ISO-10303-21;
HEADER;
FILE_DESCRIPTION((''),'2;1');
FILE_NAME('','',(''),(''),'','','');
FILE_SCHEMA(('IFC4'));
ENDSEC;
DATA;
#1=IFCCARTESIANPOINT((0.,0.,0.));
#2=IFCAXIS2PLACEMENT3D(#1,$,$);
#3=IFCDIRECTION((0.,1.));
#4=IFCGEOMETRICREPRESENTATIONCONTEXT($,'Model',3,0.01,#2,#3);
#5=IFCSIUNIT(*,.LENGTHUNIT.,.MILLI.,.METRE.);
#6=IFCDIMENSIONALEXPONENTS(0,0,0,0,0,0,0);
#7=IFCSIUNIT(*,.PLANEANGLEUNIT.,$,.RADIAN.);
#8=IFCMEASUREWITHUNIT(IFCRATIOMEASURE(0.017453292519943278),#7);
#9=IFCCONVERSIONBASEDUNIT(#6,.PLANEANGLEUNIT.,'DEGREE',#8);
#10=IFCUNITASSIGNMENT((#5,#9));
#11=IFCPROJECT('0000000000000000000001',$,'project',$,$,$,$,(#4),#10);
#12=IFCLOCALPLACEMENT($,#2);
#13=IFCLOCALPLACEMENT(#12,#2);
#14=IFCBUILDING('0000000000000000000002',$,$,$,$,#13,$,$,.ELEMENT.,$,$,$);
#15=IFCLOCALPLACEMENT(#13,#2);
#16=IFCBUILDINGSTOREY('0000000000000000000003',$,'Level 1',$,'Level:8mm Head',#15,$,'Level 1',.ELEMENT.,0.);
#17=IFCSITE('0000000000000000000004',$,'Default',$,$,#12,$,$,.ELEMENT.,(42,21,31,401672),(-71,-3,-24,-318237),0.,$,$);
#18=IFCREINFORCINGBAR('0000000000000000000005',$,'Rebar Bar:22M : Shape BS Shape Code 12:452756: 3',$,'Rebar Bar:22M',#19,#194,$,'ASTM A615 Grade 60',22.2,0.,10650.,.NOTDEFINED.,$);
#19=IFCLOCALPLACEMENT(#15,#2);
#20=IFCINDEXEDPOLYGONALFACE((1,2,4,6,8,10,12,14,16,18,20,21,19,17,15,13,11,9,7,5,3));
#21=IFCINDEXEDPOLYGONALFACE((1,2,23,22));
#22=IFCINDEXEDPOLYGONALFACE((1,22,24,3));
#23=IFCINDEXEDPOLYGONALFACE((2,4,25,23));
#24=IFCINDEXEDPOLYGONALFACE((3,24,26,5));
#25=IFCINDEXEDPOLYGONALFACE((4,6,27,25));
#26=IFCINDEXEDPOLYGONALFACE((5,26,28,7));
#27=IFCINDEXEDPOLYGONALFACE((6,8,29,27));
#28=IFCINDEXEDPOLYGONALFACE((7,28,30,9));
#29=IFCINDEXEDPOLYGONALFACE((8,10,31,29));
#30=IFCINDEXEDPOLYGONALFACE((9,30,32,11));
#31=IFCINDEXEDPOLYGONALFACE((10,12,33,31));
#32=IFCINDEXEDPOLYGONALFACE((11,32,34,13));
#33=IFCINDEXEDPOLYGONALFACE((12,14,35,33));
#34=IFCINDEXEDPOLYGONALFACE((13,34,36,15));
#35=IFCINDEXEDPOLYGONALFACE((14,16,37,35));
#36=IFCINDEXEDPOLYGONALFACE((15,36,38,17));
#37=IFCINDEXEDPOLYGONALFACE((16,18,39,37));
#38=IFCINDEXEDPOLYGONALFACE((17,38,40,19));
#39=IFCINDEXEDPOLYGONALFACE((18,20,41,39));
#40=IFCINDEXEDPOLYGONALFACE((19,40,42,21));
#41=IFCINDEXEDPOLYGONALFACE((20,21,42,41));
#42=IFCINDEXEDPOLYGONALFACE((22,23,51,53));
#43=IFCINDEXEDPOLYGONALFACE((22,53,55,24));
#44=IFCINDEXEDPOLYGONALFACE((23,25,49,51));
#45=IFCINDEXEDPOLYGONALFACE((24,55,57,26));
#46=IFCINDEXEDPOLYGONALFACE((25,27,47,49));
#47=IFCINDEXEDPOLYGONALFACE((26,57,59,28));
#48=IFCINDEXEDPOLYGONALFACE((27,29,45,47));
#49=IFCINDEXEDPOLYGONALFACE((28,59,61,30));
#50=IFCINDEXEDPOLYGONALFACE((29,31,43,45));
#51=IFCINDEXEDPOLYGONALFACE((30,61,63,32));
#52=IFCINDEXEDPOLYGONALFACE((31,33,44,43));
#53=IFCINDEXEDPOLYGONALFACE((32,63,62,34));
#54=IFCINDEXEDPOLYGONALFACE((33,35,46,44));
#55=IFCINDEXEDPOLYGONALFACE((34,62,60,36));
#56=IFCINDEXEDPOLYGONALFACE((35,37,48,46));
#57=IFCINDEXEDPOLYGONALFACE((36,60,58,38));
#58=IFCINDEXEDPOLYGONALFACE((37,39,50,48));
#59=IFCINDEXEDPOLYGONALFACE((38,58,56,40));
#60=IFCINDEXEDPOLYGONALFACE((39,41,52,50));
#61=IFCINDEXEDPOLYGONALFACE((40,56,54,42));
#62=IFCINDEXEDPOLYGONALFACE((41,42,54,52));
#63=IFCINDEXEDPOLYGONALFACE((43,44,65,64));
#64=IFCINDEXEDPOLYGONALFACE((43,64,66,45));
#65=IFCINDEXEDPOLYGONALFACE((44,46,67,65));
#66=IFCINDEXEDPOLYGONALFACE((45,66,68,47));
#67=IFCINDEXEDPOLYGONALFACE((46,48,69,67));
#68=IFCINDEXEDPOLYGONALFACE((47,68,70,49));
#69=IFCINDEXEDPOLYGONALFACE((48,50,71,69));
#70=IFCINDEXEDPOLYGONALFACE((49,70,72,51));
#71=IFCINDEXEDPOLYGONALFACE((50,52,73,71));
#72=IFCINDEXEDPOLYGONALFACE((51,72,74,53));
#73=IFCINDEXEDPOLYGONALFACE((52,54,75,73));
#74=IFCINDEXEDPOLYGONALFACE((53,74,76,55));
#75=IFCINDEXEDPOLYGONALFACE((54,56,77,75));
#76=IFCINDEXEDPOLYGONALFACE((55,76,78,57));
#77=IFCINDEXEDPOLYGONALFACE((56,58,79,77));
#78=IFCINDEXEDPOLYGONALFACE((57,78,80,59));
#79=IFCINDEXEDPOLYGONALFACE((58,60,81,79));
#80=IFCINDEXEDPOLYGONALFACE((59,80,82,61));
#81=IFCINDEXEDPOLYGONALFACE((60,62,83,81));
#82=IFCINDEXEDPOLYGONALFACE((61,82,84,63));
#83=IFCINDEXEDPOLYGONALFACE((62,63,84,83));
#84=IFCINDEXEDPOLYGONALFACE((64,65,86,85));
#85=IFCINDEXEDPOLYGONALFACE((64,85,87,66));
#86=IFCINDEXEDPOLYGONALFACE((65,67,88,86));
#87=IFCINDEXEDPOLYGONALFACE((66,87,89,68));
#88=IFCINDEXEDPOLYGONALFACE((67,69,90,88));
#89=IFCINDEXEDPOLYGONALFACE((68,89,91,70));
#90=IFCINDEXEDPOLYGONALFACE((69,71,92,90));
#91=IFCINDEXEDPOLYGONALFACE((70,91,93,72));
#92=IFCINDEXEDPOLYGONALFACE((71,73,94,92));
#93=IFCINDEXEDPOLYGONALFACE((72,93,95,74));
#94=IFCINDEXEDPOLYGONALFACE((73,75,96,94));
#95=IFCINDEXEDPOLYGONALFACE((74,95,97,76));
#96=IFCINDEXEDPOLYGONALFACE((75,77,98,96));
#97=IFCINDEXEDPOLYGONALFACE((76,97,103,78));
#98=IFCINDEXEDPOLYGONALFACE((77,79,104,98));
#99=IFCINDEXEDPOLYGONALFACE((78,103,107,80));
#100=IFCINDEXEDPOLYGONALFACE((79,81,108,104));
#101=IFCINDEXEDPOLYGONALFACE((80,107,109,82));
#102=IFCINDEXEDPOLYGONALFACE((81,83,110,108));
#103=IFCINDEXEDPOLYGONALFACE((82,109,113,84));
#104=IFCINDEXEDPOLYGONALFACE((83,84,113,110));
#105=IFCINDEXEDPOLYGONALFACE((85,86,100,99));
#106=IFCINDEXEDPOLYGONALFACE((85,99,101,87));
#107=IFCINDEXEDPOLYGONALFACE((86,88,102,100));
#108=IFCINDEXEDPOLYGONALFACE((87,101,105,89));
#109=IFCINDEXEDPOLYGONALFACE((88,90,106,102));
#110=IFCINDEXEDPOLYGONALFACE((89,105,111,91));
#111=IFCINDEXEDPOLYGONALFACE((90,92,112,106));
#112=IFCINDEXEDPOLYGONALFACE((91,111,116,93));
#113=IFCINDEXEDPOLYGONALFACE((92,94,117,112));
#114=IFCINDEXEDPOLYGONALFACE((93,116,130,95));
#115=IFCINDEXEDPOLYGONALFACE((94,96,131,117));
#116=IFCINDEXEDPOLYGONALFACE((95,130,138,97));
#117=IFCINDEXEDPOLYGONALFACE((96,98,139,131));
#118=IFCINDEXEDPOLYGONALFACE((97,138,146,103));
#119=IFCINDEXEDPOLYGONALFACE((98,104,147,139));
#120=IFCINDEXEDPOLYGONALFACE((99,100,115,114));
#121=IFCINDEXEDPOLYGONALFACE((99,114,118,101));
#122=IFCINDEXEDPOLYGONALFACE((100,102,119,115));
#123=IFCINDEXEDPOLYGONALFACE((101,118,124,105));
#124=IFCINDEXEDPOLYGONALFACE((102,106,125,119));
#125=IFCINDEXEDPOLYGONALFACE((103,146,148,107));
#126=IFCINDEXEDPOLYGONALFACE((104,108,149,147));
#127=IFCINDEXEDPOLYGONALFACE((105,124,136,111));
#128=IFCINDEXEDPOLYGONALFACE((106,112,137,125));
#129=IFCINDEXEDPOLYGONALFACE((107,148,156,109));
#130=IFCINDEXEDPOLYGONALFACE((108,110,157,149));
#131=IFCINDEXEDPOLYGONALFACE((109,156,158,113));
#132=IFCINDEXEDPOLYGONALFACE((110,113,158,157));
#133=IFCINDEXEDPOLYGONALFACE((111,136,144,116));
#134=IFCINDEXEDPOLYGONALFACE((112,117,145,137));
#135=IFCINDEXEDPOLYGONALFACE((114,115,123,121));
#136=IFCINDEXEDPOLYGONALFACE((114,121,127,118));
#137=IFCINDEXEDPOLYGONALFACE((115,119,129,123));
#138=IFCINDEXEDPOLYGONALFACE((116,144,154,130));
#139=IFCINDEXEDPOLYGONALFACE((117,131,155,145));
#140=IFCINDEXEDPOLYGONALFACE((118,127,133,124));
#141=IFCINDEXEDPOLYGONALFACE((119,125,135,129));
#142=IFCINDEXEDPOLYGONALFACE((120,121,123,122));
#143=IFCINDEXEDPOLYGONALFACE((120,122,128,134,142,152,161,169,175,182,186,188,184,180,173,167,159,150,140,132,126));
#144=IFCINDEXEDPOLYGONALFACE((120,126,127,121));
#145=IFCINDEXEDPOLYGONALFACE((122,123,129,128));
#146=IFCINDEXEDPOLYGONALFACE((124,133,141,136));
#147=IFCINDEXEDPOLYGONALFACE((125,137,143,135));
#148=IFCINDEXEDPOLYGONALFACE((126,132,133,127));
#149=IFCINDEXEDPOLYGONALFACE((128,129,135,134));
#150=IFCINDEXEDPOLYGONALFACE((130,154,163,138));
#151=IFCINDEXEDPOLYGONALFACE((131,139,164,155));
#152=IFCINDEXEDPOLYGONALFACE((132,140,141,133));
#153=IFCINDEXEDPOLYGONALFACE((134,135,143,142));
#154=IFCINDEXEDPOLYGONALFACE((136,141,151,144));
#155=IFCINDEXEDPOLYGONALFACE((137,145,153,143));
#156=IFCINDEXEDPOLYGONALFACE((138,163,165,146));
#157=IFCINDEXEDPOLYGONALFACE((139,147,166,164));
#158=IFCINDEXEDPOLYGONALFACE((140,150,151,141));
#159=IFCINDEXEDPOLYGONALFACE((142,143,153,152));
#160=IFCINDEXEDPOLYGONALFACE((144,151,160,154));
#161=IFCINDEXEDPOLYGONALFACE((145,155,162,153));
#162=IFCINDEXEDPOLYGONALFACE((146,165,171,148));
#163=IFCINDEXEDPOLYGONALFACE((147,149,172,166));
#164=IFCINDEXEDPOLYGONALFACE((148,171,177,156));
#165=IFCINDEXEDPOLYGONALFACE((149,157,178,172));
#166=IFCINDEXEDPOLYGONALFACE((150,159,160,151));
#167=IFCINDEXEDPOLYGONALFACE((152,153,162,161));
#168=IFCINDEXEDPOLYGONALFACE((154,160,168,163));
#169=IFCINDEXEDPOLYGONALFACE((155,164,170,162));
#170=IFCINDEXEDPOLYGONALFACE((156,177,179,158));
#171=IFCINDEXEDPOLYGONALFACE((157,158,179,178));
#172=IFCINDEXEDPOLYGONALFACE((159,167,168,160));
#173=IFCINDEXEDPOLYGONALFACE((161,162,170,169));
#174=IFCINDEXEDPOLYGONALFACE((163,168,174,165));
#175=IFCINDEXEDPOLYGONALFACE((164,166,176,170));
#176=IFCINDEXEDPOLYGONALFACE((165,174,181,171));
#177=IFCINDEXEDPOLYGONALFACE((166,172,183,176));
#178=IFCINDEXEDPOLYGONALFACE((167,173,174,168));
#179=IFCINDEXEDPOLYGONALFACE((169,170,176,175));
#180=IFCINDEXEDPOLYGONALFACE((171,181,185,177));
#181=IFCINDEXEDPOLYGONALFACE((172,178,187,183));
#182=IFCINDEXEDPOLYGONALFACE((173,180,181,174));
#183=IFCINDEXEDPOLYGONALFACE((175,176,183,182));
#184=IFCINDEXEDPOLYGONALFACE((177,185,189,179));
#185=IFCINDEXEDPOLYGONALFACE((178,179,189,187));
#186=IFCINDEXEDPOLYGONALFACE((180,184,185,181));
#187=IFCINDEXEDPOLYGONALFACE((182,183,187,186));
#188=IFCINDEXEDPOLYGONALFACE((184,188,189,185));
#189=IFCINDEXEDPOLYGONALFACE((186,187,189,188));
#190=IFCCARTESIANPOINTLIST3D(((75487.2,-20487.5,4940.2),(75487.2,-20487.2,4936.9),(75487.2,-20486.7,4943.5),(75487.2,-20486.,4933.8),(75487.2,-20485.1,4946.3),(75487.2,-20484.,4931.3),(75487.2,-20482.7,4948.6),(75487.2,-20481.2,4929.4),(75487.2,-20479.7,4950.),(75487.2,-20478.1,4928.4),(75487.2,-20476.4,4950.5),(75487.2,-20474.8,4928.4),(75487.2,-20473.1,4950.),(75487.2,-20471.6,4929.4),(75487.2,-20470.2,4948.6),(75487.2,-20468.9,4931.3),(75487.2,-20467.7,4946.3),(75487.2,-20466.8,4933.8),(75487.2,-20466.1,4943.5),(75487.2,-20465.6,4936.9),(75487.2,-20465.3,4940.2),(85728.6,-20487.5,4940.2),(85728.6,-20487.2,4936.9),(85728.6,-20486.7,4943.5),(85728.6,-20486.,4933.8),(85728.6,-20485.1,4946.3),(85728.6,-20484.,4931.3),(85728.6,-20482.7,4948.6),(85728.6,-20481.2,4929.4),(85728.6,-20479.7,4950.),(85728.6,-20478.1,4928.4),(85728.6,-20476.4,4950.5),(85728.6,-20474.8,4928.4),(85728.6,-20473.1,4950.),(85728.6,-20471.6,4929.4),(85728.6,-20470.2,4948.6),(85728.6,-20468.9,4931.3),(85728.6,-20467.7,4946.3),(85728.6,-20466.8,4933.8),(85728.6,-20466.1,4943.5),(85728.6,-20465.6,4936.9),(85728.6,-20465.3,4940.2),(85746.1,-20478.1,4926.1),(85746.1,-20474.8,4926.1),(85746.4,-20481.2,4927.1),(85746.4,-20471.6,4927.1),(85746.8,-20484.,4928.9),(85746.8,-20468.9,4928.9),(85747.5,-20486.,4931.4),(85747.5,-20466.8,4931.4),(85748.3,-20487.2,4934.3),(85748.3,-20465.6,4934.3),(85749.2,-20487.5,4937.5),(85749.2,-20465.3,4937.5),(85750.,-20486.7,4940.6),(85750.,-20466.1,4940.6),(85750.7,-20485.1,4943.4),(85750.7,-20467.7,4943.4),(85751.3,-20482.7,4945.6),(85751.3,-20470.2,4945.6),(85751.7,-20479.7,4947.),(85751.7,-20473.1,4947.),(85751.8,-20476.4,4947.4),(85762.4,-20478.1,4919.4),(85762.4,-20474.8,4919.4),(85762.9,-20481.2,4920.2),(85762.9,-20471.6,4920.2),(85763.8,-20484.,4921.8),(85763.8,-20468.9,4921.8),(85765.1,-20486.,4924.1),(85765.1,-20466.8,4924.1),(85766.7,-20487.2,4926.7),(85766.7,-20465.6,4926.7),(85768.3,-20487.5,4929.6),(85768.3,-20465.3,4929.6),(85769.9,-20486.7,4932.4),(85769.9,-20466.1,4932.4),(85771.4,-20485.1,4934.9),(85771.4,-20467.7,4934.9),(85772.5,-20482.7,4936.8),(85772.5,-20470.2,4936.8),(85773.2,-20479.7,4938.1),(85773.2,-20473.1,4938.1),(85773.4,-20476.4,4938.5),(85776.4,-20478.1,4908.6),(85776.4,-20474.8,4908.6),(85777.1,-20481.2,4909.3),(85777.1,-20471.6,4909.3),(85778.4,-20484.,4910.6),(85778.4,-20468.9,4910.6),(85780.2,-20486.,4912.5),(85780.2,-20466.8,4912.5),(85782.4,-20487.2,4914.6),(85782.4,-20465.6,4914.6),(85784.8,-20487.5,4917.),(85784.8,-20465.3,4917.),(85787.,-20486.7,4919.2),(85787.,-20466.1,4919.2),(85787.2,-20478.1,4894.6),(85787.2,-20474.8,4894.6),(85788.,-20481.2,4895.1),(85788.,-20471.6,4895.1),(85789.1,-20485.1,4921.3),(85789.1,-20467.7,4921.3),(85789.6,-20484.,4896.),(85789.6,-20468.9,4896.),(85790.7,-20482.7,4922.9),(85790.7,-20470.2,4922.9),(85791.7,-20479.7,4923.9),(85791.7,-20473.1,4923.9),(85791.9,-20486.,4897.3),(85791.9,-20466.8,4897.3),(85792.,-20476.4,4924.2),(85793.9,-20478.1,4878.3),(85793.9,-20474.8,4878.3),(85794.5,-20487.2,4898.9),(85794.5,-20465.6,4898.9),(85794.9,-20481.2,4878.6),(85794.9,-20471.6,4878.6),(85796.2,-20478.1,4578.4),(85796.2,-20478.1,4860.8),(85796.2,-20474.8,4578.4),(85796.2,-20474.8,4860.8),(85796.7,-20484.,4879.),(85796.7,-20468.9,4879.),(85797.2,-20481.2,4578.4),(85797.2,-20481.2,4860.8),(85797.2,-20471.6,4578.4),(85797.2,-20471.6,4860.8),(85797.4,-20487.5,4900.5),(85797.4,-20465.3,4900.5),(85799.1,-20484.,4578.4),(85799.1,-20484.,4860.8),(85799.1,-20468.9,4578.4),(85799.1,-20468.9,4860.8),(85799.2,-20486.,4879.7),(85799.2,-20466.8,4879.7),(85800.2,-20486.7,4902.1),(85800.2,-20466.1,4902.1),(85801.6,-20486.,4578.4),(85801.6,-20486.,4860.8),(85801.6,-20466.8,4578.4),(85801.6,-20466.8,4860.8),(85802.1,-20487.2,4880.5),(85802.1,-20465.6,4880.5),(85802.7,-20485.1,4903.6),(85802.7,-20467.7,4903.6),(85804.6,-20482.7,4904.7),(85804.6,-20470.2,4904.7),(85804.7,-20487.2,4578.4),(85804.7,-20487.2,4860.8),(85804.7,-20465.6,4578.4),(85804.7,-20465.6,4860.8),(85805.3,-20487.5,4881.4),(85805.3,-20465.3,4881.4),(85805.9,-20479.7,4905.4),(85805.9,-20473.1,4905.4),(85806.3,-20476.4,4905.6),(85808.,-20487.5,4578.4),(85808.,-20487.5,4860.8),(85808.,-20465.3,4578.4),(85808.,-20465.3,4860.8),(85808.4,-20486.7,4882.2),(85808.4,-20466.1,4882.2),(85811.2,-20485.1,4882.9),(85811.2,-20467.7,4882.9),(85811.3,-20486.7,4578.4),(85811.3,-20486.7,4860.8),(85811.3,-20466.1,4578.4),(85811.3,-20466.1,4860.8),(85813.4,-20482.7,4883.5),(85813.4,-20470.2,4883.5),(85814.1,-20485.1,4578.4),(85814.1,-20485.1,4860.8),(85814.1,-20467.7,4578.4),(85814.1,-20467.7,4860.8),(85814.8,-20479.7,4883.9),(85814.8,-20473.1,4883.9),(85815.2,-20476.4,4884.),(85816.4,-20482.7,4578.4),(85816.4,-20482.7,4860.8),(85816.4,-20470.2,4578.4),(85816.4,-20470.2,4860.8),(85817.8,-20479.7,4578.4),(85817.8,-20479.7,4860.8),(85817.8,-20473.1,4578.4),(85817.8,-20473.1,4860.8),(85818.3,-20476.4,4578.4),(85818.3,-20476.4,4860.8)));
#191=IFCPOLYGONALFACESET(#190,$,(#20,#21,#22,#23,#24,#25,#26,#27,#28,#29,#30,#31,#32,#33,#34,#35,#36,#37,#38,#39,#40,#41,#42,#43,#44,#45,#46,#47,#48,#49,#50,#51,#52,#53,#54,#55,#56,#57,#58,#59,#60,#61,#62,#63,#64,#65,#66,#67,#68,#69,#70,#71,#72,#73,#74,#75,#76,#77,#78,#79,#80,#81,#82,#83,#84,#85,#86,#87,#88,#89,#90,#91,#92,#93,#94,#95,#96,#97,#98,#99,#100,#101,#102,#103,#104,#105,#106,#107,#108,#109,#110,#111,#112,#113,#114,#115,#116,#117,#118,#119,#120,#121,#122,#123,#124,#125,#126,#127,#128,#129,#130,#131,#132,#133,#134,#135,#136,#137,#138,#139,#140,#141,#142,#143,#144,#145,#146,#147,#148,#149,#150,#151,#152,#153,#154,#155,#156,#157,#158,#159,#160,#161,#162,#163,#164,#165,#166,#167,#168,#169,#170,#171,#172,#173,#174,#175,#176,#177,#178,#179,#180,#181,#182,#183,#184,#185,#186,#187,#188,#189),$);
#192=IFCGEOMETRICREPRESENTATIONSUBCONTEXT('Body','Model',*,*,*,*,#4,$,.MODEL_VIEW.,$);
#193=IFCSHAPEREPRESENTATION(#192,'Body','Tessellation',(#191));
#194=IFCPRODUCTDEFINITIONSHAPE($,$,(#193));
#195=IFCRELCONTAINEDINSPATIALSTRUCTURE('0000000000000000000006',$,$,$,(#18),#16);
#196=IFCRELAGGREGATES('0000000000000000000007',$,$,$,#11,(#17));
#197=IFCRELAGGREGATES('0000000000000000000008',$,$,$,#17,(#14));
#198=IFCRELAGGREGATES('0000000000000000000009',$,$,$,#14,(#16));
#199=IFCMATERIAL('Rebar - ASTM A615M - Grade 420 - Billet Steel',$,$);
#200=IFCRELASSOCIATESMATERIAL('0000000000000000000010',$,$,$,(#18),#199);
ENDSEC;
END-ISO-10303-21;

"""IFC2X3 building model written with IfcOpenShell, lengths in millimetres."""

from ifc_helpers import new_model, entity, si_unit, converted_unit, direction, origin, place, context, subcontext, project, spatial, material, element, save


model = new_model("IFC2X3")

# Units and contexts
model_context = context("Model", 3, precision=0.01, world=origin(), true_north=direction((0.0, 1.0)))
body_context = subcontext(model_context, "Body", "Model", "MODEL_VIEW")
ifc_project = project(units=[si_unit("LENGTHUNIT", "METRE", prefix="MILLI"), converted_unit("PLANEANGLEUNIT", "DEGREE", entity("IfcRatioMeasure", 0.017453292519943278), si_unit("PLANEANGLEUNIT", "RADIAN"), dimensions=[0, 0, 0, 0, 0, 0, 0])], contexts=[model_context])

# Site, building, storey
site_placement = place(None, origin())
site = spatial("IfcSite", under=ifc_project, at=site_placement, Name="Default", CompositionType="ELEMENT", RefLatitude=(42, 21, 31, 401672), RefLongitude=(-71, -3, -24, -318237), RefElevation=0.0)
building_placement = place(site_placement, origin())
building = spatial("IfcBuilding", under=site, at=building_placement, CompositionType="ELEMENT")
storey_placement = place(building_placement, origin())
storey = spatial("IfcBuildingStorey", under=building, at=storey_placement, Name="Level 1", ObjectType="Level:8mm Head", LongName="Level 1", CompositionType="ELEMENT", Elevation=0.0)

# Reinforcing bar
ifc_material = material(Name="Rebar - ASTM A615M - Grade 420 - Billet Steel")
reinforcing_bar_1_placement = place(storey_placement, origin())
element("IfcReinforcingBar", 1, at=reinforcing_bar_1_placement, inside=storey, material=ifc_material, Name="Rebar Bar:22M : Shape BS Shape Code 12:452756: 3", SteelGrade="ASTM A615 Grade 60", ObjectType="Rebar Bar:22M", BarLength=10650.0, BarRole="NOTDEFINED", CrossSectionArea=0.0, NominalDiameter=22.2, context=body_context, shape_type="AdvancedSweptSolid", body=[
    entity("IfcSweptDiskSolid", entity("IfcCompositeCurve", [entity("IfcCompositeCurveSegment", "CONTINUOUS", True, entity("IfcPolyline", [entity("IfcCartesianPoint", [75487.2, -20476.4, 4939.4]), entity("IfcCartesianPoint", [85728.6, -20476.4, 4939.4])])), entity("IfcCompositeCurveSegment", "CONTINUOUS", True, entity("IfcTrimmedCurve", entity("IfcCircle", entity("IfcAxis2Placement3D", entity("IfcCartesianPoint", [85728.6, -20476.4, 4860.8]), entity("IfcDirection", [0.0, 1.0, 0.0]), entity("IfcDirection", [1.0, 0.0, 0.0])), 78.6), [entity("IfcParameterValue", 270.0)], [entity("IfcParameterValue", 360.0)], True, "PARAMETER")), entity("IfcCompositeCurveSegment", "CONTINUOUS", True, entity("IfcPolyline", [entity("IfcCartesianPoint", [85807.2, -20476.4, 4860.8]), entity("IfcCartesianPoint", [85807.2, -20476.4, 4578.4])]))], False), 11.1, None, 0.0, 92.0),
])

save(model, "model.ifc")
